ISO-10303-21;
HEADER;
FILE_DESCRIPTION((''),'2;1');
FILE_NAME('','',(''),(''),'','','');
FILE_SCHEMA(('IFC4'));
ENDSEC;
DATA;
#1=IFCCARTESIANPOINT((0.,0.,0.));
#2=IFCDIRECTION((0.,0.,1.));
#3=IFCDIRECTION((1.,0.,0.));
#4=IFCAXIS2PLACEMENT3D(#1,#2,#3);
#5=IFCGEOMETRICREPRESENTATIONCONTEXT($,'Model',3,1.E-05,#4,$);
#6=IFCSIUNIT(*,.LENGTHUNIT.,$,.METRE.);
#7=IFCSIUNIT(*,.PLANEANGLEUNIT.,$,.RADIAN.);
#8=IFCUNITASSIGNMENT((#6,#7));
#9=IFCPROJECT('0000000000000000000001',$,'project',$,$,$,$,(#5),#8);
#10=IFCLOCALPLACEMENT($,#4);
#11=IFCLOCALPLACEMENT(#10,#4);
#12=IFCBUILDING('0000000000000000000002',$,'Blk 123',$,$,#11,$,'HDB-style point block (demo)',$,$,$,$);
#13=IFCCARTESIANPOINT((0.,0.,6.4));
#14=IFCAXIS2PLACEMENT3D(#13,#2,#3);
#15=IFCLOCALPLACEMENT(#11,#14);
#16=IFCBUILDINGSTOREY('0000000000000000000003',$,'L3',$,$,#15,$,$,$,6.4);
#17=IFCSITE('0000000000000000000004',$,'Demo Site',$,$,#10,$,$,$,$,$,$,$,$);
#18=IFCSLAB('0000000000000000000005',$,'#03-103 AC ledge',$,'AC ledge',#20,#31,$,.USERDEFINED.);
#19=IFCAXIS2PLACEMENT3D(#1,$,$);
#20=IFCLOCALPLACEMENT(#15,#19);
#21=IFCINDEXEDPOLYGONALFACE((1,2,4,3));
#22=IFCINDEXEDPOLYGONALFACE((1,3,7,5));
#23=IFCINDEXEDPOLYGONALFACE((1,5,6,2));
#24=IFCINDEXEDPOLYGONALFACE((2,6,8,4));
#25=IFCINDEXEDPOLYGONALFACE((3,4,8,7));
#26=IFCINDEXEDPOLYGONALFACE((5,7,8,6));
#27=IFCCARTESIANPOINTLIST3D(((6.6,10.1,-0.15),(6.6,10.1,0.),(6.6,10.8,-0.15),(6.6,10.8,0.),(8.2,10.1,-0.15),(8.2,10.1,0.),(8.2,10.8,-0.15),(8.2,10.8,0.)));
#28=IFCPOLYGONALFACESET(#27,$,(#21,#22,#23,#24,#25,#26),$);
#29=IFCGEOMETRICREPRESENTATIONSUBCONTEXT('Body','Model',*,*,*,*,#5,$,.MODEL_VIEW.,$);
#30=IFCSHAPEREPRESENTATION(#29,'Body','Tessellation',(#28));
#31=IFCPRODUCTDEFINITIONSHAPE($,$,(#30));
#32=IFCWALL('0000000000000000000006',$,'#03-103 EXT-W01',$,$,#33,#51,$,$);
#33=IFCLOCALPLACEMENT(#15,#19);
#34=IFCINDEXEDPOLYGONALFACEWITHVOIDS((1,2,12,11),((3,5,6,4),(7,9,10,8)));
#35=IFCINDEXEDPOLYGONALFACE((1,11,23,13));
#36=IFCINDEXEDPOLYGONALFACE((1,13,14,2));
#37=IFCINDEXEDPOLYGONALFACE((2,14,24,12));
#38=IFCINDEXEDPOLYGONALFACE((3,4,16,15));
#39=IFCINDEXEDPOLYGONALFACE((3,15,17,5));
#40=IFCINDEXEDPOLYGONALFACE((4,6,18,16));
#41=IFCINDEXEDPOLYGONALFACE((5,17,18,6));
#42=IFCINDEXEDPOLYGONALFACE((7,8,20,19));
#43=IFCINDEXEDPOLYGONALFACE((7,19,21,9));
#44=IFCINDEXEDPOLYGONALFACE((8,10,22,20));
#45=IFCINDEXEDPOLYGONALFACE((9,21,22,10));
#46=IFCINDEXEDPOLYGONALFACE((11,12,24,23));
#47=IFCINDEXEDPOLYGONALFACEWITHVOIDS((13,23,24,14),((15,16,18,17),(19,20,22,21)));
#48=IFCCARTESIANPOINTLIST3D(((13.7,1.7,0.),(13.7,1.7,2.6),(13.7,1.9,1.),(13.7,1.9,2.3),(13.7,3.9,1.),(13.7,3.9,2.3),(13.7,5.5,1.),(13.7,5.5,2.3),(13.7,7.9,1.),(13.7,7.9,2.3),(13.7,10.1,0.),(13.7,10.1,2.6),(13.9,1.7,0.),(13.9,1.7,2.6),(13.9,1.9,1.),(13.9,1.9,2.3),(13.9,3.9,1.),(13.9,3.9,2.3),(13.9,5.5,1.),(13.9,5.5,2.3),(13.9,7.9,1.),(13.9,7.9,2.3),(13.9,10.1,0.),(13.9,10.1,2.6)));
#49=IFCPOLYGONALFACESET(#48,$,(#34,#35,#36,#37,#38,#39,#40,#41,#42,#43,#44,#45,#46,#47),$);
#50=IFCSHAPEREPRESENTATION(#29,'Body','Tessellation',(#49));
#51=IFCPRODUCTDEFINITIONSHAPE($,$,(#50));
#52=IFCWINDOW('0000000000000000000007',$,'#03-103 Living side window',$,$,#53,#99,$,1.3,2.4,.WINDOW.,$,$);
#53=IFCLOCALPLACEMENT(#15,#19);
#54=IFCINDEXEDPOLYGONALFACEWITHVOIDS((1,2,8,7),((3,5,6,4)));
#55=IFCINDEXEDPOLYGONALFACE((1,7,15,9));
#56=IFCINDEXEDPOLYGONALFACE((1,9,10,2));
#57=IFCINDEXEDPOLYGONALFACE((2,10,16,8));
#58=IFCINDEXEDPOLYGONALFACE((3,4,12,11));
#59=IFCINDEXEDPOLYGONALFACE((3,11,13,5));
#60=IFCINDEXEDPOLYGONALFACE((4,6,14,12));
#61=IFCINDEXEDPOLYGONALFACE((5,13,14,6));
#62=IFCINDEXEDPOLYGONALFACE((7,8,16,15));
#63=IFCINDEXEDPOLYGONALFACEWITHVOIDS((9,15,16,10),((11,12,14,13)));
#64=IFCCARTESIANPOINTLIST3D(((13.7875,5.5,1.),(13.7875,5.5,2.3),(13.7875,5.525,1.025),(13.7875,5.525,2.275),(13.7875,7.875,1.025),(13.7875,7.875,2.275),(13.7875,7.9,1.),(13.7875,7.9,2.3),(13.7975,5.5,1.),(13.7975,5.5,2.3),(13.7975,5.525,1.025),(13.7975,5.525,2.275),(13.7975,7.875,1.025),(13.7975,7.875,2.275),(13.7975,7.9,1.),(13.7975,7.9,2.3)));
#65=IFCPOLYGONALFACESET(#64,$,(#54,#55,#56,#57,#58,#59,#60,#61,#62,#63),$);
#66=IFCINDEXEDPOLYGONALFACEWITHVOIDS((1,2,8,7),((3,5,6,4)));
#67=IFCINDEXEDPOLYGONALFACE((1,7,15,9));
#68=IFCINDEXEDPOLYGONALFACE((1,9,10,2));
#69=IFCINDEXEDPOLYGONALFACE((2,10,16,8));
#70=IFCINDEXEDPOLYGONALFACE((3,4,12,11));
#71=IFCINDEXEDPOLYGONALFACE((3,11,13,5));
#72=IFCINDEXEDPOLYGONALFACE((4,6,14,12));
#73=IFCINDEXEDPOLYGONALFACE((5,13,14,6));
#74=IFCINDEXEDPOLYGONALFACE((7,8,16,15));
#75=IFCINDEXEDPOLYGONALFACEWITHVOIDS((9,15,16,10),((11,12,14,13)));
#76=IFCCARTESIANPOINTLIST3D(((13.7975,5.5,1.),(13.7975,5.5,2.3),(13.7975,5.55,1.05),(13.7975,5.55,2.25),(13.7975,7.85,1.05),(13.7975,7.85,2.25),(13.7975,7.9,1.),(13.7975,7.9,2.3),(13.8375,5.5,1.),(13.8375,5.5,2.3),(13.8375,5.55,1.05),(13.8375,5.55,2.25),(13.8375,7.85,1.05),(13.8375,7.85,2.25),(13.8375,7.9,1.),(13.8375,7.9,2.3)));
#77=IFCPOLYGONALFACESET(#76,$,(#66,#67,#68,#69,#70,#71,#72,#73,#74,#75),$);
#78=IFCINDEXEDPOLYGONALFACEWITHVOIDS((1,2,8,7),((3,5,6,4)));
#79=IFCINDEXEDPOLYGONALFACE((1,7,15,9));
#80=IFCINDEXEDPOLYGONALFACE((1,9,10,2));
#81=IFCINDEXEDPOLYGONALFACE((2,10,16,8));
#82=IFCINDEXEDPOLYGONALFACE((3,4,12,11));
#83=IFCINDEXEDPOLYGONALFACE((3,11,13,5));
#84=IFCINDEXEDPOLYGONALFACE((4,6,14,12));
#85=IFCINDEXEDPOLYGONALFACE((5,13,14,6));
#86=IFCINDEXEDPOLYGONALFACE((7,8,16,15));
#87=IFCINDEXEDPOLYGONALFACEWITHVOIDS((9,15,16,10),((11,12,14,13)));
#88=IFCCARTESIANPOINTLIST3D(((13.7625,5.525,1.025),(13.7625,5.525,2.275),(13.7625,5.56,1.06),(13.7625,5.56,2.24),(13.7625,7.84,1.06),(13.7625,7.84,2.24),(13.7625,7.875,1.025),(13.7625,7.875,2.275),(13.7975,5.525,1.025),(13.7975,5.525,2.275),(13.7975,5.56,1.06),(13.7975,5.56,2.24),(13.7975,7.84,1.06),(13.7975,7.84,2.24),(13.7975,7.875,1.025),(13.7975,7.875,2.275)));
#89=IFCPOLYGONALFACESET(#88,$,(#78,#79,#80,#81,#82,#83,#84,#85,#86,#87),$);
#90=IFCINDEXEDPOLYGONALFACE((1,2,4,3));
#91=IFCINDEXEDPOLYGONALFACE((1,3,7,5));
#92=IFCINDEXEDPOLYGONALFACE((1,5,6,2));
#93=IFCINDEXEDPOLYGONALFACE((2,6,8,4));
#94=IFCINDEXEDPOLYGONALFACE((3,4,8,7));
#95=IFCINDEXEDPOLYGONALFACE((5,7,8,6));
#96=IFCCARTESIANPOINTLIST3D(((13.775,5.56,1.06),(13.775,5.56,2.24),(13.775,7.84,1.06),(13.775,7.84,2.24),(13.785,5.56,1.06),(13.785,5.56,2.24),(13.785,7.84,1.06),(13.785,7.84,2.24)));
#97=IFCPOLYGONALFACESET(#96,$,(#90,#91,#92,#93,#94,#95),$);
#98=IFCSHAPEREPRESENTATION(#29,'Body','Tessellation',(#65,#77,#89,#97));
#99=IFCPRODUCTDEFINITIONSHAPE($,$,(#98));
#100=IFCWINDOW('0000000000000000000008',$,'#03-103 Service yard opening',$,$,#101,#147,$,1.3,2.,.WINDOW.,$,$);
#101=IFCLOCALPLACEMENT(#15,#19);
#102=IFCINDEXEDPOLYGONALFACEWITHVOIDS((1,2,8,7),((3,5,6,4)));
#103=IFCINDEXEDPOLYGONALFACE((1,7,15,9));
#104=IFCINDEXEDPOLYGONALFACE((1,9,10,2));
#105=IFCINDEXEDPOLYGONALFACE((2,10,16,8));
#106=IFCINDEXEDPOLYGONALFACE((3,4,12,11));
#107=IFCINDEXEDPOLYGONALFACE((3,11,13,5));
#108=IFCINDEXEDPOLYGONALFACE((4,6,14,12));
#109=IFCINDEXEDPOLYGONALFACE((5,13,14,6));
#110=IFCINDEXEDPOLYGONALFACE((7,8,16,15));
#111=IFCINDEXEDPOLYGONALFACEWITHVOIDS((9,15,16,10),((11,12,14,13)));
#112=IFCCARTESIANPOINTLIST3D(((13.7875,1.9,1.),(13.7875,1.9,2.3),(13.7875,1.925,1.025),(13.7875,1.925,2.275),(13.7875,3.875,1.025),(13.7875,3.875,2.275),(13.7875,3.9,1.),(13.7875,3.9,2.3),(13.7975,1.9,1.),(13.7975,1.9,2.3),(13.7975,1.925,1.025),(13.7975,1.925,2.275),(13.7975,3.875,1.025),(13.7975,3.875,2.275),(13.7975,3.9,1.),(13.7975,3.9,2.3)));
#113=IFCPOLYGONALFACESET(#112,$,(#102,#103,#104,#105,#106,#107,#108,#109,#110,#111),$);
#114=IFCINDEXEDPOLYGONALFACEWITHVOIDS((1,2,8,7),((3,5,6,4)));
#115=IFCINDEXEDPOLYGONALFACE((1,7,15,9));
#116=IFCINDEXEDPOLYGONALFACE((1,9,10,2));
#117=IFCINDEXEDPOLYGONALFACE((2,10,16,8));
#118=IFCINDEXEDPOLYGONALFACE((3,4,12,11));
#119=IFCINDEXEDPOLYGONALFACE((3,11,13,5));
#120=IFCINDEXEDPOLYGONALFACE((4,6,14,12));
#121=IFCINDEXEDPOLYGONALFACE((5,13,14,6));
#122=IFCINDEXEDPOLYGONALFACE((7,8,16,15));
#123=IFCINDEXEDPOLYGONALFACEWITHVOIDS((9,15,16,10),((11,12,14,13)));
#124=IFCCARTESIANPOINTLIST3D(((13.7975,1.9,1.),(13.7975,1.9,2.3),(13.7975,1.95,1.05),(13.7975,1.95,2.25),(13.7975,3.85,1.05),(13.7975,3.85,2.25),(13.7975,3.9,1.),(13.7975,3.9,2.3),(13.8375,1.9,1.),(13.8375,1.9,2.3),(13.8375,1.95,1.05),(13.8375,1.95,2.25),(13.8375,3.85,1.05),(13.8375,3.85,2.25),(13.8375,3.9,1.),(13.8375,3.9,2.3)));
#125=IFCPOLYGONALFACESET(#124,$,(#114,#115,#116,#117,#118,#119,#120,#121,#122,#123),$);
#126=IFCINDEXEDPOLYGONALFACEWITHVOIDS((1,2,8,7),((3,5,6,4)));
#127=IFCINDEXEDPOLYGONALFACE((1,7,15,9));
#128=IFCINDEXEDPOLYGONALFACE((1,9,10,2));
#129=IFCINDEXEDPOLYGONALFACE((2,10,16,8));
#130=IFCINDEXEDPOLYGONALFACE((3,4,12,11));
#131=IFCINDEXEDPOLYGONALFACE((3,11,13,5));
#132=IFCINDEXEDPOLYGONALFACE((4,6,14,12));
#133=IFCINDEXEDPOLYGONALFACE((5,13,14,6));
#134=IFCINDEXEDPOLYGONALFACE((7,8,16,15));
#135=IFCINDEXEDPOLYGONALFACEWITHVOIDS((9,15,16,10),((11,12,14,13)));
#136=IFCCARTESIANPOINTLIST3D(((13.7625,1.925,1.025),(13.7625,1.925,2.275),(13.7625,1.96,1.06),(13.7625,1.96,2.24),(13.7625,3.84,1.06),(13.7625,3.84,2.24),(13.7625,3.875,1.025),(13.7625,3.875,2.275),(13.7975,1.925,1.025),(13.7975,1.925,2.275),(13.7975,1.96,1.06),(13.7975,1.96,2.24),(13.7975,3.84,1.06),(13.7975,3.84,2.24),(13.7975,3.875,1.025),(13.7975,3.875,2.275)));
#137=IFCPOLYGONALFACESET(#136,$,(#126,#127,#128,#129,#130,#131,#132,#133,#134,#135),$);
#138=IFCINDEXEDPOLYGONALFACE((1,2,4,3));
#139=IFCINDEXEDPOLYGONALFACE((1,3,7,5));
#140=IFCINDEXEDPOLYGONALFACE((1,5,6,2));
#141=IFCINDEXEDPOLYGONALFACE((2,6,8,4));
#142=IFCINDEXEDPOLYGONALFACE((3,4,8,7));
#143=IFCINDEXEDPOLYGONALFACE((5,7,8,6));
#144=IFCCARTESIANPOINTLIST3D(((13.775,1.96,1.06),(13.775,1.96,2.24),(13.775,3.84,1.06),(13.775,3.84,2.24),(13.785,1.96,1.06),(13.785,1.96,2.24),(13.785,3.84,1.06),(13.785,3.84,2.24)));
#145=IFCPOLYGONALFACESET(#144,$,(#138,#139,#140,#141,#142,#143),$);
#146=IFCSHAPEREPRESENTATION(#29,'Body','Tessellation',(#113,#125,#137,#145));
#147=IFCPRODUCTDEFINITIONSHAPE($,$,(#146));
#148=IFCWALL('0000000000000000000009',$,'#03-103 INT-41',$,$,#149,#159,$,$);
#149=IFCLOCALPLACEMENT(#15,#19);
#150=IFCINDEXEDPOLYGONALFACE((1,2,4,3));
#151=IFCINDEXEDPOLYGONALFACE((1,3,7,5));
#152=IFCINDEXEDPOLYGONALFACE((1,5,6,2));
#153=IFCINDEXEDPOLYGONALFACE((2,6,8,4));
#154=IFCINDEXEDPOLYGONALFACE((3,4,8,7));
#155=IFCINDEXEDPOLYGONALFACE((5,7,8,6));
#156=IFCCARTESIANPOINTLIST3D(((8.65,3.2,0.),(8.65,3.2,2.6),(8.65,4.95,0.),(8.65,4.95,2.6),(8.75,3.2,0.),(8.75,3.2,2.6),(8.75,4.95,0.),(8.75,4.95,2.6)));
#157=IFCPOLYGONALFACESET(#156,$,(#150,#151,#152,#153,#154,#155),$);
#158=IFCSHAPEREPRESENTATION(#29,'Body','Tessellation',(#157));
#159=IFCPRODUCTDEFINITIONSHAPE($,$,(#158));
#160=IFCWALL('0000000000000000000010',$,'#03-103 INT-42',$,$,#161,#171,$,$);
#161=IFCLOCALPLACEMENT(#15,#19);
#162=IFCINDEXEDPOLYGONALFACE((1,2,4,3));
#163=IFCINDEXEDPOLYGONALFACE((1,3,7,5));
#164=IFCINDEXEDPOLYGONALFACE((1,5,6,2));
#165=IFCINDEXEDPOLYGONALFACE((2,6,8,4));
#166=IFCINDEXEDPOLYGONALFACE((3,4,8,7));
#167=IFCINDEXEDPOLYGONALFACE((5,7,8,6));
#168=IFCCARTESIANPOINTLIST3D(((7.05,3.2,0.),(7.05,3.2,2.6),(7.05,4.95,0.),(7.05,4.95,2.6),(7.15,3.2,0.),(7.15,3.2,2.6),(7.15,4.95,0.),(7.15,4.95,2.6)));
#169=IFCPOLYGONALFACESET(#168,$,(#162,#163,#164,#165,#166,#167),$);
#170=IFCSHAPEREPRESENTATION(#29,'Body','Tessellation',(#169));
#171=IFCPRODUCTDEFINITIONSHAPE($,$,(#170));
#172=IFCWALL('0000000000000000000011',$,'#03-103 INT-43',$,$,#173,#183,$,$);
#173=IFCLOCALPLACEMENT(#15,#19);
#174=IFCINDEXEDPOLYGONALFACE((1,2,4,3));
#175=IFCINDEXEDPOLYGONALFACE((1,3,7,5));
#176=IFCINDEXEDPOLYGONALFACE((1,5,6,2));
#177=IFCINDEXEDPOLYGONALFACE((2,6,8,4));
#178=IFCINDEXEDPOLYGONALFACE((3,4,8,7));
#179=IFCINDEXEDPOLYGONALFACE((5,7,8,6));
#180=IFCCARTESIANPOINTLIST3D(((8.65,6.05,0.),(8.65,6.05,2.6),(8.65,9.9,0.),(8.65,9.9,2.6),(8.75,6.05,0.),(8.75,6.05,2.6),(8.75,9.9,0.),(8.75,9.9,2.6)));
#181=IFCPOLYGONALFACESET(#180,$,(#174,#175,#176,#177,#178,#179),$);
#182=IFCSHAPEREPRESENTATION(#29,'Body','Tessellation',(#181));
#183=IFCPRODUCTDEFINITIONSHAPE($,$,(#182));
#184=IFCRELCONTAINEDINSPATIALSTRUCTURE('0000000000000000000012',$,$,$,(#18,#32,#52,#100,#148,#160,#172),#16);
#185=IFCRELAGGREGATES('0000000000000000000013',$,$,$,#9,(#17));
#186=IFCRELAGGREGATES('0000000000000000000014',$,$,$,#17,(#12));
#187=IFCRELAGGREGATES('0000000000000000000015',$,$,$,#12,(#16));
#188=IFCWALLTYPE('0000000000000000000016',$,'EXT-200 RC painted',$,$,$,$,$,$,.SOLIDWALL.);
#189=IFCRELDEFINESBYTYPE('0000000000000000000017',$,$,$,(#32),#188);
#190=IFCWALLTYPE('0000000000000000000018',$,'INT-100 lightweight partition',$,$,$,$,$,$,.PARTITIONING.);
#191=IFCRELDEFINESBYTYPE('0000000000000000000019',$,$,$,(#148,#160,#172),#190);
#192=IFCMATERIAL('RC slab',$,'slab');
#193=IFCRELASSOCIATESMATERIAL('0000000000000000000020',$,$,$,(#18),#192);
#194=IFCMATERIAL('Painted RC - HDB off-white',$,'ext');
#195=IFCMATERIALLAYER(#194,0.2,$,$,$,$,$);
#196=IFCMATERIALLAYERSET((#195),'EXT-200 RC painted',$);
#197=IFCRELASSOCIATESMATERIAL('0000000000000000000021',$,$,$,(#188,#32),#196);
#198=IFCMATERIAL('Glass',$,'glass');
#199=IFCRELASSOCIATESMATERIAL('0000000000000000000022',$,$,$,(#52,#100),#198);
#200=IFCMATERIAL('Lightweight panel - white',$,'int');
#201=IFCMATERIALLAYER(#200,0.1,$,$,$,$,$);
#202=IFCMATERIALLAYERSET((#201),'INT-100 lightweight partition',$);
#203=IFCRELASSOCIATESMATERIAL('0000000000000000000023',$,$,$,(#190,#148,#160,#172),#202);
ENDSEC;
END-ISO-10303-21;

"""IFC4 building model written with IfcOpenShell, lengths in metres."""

from ifc_helpers import new_model, si_unit, frame, origin, origin_with_axes, place, context, subcontext, project, spatial, polyline, line, indexed_curve, outline, extrude, material, layer, layer_set, layer_usage, type_object, element, fill, save


model = new_model("IFC4")

# Units and contexts
model_context = context("Model", 3, precision=1e-05, world=origin_with_axes())
body_context = subcontext(model_context, "Body", "Model", "MODEL_VIEW")
ifc_project = project(units=[si_unit("LENGTHUNIT", "METRE"), si_unit("PLANEANGLEUNIT", "RADIAN")], contexts=[model_context])

# Site, building, storey
site_placement = place(None, origin_with_axes())
site = spatial("IfcSite", under=ifc_project, at=site_placement, Name="Demo Site")
building_placement = place(site_placement, origin_with_axes())
building = spatial("IfcBuilding", under=site, at=building_placement, Name="Blk 123", LongName="HDB-style point block (demo)")
storey_placement = place(building_placement, frame((0.0, 0.0, 6.4), z_axis=(0.0, 0.0, 1.0), x_axis=(1.0, 0.0, 0.0)))
storey = spatial("IfcBuildingStorey", under=building, at=storey_placement, Name="L3", Elevation=6.4)

# Slab
ifc_material_1 = material(Name="RC slab", Category="slab")
slab_placement = place(storey_placement, frame((7.4, 10.45, -0.15), z_axis=(0.0, 0.0, 1.0), x_axis=(1.0, 0.0, 0.0)))
element("IfcSlab", 1, at=slab_placement, inside=storey, material=ifc_material_1, Name="#03-103 AC ledge", ObjectType="AC ledge", PredefinedType="USERDEFINED", context=body_context, shape_type="SweptSolid", body=[
    extrude(outline(polyline([(0.8, -0.35), (0.8, 0.35), (-0.8, 0.35), (-0.8, -0.35), (0.8, -0.35)])), origin(), (0.0, 0.0, 1.0), 0.15),
])

# Wall, openings, windows
ifc_material_2 = material(Name="Painted RC - HDB off-white", Category="ext")
ifc_layer_1 = layer(ifc_material_2, 0.2)
ifc_layer_set_1 = layer_set([ifc_layer_1], Name="EXT-200 RC painted")
ifc_layer_usage_1 = layer_usage(ifc_layer_set_1, "AXIS2", "POSITIVE", 0.0)
wall_type_1 = type_object("IfcWallType", Name="EXT-200 RC painted", PredefinedType="SOLIDWALL", material=ifc_layer_set_1)
wall_1_placement = place(storey_placement, frame((13.9, 1.7, 0.0), z_axis=(0.0, 0.0, 1.0), x_axis=(0.0, 1.0, 0.0)))
wall_1 = element("IfcWall", 2, at=wall_1_placement, inside=storey, type_object=wall_type_1, material=ifc_layer_usage_1, Name="#03-103 EXT-W01", context=body_context, shape_type="SweptSolid", body=[
    extrude(outline(indexed_curve([(0.0, 0.0), (0.0, 0.2), (8.4, 0.2), (8.4, 0.0), (0.0, 0.0)], self_intersect=False)), origin_with_axes(), (0.0, 0.0, 1.0), 2.6),
])
opening_1_placement = place(wall_1_placement, frame((3.8, -0.1, 1.0), z_axis=(0.0, 0.0, 1.0), x_axis=(1.0, 0.0, 0.0)))
opening_1 = element("IfcOpeningElement", 3, at=opening_1_placement, cuts=wall_1, context=body_context, shape_type="SweptSolid", body=[
    extrude(outline(indexed_curve([(0.0, 0.0), (0.0, 0.4), (2.4, 0.4), (2.4, 0.0), (0.0, 0.0)], self_intersect=False)), origin_with_axes(), (0.0, 0.0, 1.0), 1.3),
])
opening_2_placement = place(wall_1_placement, frame((0.2, -0.1, 1.0), z_axis=(0.0, 0.0, 1.0), x_axis=(1.0, 0.0, 0.0)))
opening_2 = element("IfcOpeningElement", 4, at=opening_2_placement, cuts=wall_1, context=body_context, shape_type="SweptSolid", body=[
    extrude(outline(indexed_curve([(0.0, 0.0), (0.0, 0.4), (2.0, 0.4), (2.0, 0.0), (0.0, 0.0)], self_intersect=False)), origin_with_axes(), (0.0, 0.0, 1.0), 1.3),
])
ifc_material_3 = material(Name="Glass", Category="glass")
window_1_placement = place(opening_1_placement, frame((0.0, 0.1125, 0.0), z_axis=(0.0, 0.0, 1.0), x_axis=(1.0, 0.0, 0.0)))
window_1 = element("IfcWindow", 5, at=window_1_placement, inside=storey, material=ifc_material_3, Name="#03-103 Living side window", OverallHeight=1.3, OverallWidth=2.4, PredefinedType="WINDOW", context=body_context, shape_type="SweptSolid", body=[
    extrude(outline(indexed_curve([(0.0, 0.0), (2.4, 0.0), (2.4, 1.3), (0.0, 1.3)], segments=[line(1, 2, 3, 4, 1)]), holes=[indexed_curve([(0.025, 0.025), (2.375, 0.025), (2.375, 1.275), (0.025, 1.275)], segments=[line(1, 2, 3, 4, 1)])]), frame((0.0, 0.09, 0.0), z_axis=(0.0, -1.0, 0.0), x_axis=(1.0, 0.0, 0.0)), (0.0, 0.0, -1.0), 0.01),
    extrude(outline(indexed_curve([(0.0, 0.0), (2.4, 0.0), (2.4, 1.3), (0.0, 1.3)], segments=[line(1, 2, 3, 4, 1)]), holes=[indexed_curve([(0.05, 0.05), (2.35, 0.05), (2.35, 1.25), (0.05, 1.25)], segments=[line(1, 2, 3, 4, 1)])]), frame((0.0, 0.05, 0.0), z_axis=(0.0, -1.0, 0.0), x_axis=(1.0, 0.0, 0.0)), (0.0, 0.0, -1.0), 0.04),
    extrude(outline(indexed_curve([(0.0, 0.0), (2.35, 0.0), (2.35, 1.25), (0.0, 1.25)], segments=[line(1, 2, 3, 4, 1)]), holes=[indexed_curve([(0.035, 0.035), (2.315, 0.035), (2.315, 1.215), (0.035, 1.215)], segments=[line(1, 2, 3, 4, 1)])]), frame((0.025, 0.09, 0.025), z_axis=(0.0, -1.0, 0.0), x_axis=(1.0, 0.0, 0.0)), (0.0, 0.0, -1.0), 0.035),
    extrude(outline(indexed_curve([(0.035, 0.035), (2.315, 0.035), (2.315, 1.215), (0.035, 1.215)], segments=[line(1, 2, 3, 4, 1)])), frame((0.025, 0.1025, 0.025), z_axis=(0.0, -1.0, 0.0), x_axis=(1.0, 0.0, 0.0)), (0.0, 0.0, -1.0), 0.01),
])
fill(opening_1, window_1)
window_2_placement = place(opening_2_placement, frame((0.0, 0.1125, 0.0), z_axis=(0.0, 0.0, 1.0), x_axis=(1.0, 0.0, 0.0)))
window_2 = element("IfcWindow", 6, at=window_2_placement, inside=storey, material=ifc_material_3, Name="#03-103 Service yard opening", OverallHeight=1.3, OverallWidth=2.0, PredefinedType="WINDOW", context=body_context, shape_type="SweptSolid", body=[
    extrude(outline(indexed_curve([(0.0, 0.0), (2.0, 0.0), (2.0, 1.3), (0.0, 1.3)], segments=[line(1, 2, 3, 4, 1)]), holes=[indexed_curve([(0.025, 0.025), (1.975, 0.025), (1.975, 1.275), (0.025, 1.275)], segments=[line(1, 2, 3, 4, 1)])]), frame((0.0, 0.09, 0.0), z_axis=(0.0, -1.0, 0.0), x_axis=(1.0, 0.0, 0.0)), (0.0, 0.0, -1.0), 0.01),
    extrude(outline(indexed_curve([(0.0, 0.0), (2.0, 0.0), (2.0, 1.3), (0.0, 1.3)], segments=[line(1, 2, 3, 4, 1)]), holes=[indexed_curve([(0.05, 0.05), (1.95, 0.05), (1.95, 1.25), (0.05, 1.25)], segments=[line(1, 2, 3, 4, 1)])]), frame((0.0, 0.05, 0.0), z_axis=(0.0, -1.0, 0.0), x_axis=(1.0, 0.0, 0.0)), (0.0, 0.0, -1.0), 0.04),
    extrude(outline(indexed_curve([(0.0, 0.0), (1.95, 0.0), (1.95, 1.25), (0.0, 1.25)], segments=[line(1, 2, 3, 4, 1)]), holes=[indexed_curve([(0.035, 0.035), (1.915, 0.035), (1.915, 1.215), (0.035, 1.215)], segments=[line(1, 2, 3, 4, 1)])]), frame((0.025, 0.09, 0.025), z_axis=(0.0, -1.0, 0.0), x_axis=(1.0, 0.0, 0.0)), (0.0, 0.0, -1.0), 0.035),
    extrude(outline(indexed_curve([(0.035, 0.035), (1.915, 0.035), (1.915, 1.215), (0.035, 1.215)], segments=[line(1, 2, 3, 4, 1)])), frame((0.025, 0.1025, 0.025), z_axis=(0.0, -1.0, 0.0), x_axis=(1.0, 0.0, 0.0)), (0.0, 0.0, -1.0), 0.01),
])
fill(opening_2, window_2)

# Walls
ifc_material_4 = material(Name="Lightweight panel - white", Category="int")
ifc_layer_2 = layer(ifc_material_4, 0.1)
ifc_layer_set_2 = layer_set([ifc_layer_2], Name="INT-100 lightweight partition")
ifc_layer_usage_2 = layer_usage(ifc_layer_set_2, "AXIS2", "POSITIVE", -0.05)
wall_type_2 = type_object("IfcWallType", Name="INT-100 lightweight partition", PredefinedType="PARTITIONING", material=ifc_layer_set_2)
for number, where, z_axis, x_axis, name in (
    (7, (8.7, 3.2, 0.0), (0.0, 0.0, 1.0), (0.0, 1.0, 0.0), "#03-103 INT-41"),
    (8, (7.1, 3.2, 0.0), (0.0, 0.0, 1.0), (0.0, 1.0, 0.0), "#03-103 INT-42"),
):
    element("IfcWall", number, at=place(storey_placement, frame(where, z_axis=z_axis, x_axis=x_axis)), inside=storey, type_object=wall_type_2, material=ifc_layer_usage_2, Name=name, context=body_context, shape_type="SweptSolid", body=[
        extrude(outline(indexed_curve([(0.0, 0.0), (0.0, 0.1), (1.75, 0.1), (1.75, 0.0), (0.0, 0.0)], self_intersect=False)), frame((0.0, -0.05, 0.0), z_axis=(0.0, 0.0, 1.0), x_axis=(1.0, 0.0, 0.0)), (0.0, 0.0, 1.0), 2.6),
    ])
wall_2_placement = place(storey_placement, frame((8.7, 6.05, 0.0), z_axis=(0.0, 0.0, 1.0), x_axis=(0.0, 1.0, 0.0)))
element("IfcWall", 9, at=wall_2_placement, inside=storey, type_object=wall_type_2, material=ifc_layer_usage_2, Name="#03-103 INT-43", context=body_context, shape_type="SweptSolid", body=[
    extrude(outline(indexed_curve([(0.0, 0.0), (0.0, 0.1), (3.85, 0.1), (3.85, 0.0), (0.0, 0.0)], self_intersect=False)), frame((0.0, -0.05, 0.0), z_axis=(0.0, 0.0, 1.0), x_axis=(1.0, 0.0, 0.0)), (0.0, 0.0, 1.0), 2.6),
])

save(model, "model.ifc")
